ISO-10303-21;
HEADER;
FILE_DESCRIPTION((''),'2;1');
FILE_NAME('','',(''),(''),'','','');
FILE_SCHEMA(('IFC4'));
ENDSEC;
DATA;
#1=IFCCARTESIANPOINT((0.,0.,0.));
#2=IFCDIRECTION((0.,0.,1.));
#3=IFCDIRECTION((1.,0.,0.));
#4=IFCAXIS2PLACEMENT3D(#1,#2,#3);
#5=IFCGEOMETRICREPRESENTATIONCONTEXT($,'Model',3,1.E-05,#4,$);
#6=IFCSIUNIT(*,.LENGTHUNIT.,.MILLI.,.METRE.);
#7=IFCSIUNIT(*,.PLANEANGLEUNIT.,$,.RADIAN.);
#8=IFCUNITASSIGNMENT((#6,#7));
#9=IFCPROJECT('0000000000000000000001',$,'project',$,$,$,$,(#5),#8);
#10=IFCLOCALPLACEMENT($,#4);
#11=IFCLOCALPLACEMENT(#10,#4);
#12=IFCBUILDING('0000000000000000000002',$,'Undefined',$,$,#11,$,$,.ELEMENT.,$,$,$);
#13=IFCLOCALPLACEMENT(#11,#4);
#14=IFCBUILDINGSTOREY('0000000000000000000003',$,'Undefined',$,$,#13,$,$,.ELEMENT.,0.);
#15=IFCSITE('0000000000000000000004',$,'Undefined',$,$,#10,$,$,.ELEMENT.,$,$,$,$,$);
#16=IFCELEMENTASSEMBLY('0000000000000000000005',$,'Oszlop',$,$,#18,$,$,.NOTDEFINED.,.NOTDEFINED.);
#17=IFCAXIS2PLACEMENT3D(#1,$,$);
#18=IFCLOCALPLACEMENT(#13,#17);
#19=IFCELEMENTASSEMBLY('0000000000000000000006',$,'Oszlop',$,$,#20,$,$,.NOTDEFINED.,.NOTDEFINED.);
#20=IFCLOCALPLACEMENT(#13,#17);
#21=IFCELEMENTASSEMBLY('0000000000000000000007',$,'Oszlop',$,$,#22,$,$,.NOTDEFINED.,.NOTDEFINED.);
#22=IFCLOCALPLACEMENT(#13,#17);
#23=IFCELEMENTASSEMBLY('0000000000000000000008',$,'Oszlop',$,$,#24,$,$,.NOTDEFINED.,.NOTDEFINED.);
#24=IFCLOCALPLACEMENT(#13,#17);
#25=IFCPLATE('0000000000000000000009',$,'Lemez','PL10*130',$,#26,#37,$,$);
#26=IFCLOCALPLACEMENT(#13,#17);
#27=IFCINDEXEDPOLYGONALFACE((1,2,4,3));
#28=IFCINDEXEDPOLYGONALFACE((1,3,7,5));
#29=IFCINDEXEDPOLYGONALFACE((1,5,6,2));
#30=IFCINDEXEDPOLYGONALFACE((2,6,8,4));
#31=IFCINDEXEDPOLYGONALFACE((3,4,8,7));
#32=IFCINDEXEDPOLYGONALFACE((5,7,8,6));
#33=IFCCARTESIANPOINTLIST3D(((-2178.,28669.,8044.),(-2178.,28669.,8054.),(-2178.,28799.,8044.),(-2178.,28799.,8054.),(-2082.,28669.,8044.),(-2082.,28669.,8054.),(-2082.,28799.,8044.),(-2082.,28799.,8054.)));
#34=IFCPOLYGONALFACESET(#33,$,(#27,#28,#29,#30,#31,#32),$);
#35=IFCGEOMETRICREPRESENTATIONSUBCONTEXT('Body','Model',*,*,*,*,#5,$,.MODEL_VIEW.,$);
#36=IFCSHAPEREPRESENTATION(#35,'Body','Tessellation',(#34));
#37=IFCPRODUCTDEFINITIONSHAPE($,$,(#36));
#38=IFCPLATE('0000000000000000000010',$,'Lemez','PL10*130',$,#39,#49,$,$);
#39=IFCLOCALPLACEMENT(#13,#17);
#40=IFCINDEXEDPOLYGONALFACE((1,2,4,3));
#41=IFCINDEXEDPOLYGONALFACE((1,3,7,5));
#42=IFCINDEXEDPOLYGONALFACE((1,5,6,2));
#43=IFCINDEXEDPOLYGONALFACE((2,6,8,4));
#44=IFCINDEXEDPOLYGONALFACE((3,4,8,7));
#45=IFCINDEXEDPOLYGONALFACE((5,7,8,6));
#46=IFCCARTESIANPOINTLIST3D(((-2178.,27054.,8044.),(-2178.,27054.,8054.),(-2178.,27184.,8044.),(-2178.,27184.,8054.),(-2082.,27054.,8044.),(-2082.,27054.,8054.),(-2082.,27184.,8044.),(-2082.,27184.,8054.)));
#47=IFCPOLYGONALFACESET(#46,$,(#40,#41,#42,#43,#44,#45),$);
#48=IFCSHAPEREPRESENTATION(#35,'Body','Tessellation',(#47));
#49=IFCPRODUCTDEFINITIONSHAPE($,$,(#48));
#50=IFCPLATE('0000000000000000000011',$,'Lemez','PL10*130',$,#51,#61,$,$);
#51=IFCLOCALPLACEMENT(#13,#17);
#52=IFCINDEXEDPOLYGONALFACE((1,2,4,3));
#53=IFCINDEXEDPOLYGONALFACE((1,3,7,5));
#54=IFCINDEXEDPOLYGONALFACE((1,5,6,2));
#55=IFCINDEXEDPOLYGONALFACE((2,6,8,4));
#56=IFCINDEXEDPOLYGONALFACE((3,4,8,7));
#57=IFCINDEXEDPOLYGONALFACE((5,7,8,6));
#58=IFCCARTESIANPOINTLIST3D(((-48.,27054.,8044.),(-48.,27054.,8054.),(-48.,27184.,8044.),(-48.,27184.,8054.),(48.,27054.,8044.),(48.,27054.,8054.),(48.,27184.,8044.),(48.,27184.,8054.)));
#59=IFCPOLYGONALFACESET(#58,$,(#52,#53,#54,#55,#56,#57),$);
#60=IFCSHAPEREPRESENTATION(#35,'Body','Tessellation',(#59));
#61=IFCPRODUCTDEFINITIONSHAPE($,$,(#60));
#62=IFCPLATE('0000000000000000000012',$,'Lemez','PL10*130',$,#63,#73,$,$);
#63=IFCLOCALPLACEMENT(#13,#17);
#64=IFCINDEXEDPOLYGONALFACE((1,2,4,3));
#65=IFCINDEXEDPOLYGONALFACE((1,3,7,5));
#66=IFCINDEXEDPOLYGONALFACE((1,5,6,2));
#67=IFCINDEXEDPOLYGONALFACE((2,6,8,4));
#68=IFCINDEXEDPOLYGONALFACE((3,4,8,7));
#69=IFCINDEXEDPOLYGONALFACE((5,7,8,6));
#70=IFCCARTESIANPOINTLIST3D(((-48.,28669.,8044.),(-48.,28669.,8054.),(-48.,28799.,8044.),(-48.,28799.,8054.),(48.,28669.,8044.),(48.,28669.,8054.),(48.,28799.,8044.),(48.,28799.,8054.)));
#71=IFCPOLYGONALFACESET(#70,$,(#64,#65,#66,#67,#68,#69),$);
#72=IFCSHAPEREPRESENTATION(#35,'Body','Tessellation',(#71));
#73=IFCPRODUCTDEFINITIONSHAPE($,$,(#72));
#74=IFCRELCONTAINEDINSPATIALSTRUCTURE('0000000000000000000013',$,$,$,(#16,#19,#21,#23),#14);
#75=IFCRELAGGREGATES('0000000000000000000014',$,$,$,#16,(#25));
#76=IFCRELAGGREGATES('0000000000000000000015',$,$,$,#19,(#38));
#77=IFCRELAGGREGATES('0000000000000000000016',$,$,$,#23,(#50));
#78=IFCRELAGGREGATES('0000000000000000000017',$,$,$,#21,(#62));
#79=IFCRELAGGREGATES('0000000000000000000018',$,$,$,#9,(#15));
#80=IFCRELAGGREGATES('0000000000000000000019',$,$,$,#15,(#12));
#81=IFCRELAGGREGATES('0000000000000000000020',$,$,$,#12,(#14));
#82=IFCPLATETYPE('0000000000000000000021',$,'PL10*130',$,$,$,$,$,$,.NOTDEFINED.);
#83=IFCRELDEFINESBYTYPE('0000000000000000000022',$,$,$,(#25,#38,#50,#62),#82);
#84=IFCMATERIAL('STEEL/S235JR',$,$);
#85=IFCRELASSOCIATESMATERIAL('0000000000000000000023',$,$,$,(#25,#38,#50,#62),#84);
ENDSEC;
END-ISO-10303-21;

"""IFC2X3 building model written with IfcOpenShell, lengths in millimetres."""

from ifc_helpers import new_model, si_unit, frame, origin_with_axes, place, context, subcontext, project, spatial, polyline, outline, extrude, material, type_object, element, aggregate, save


model = new_model("IFC2X3")

# Units and contexts
model_context = context("Model", 3, precision=1e-05, world=origin_with_axes())
body_context = subcontext(model_context, "Body", "Model", "MODEL_VIEW")
ifc_project = project(units=[si_unit("LENGTHUNIT", "METRE", prefix="MILLI"), si_unit("PLANEANGLEUNIT", "RADIAN")], contexts=[model_context])

# Site, building, storey
site_placement = place(None, origin_with_axes())
site = spatial("IfcSite", under=ifc_project, at=site_placement, Name="Undefined", CompositionType="ELEMENT")
building_placement = place(site_placement, origin_with_axes())
building = spatial("IfcBuilding", under=site, at=building_placement, Name="Undefined", CompositionType="ELEMENT")
storey_placement = place(building_placement, origin_with_axes())
storey = spatial("IfcBuildingStorey", under=building, at=storey_placement, Name="Undefined", CompositionType="ELEMENT", Elevation=0.0)

# Element assemblies
assembly_1_placement = place(storey_placement, origin_with_axes())
assembly_1 = element("IfcElementAssembly", 1, at=assembly_1_placement, inside=storey, Name="Oszlop", AssemblyPlace="NOTDEFINED", PredefinedType="NOTDEFINED")
ifc_material_1 = material(Name="STEEL/S235JR")
assembly_2_placement = place(storey_placement, origin_with_axes())
assembly_2 = element("IfcElementAssembly", 2, at=assembly_2_placement, inside=storey, Name="Oszlop", AssemblyPlace="NOTDEFINED", PredefinedType="NOTDEFINED")
assembly_3_placement = place(storey_placement, origin_with_axes())
assembly_3 = element("IfcElementAssembly", 3, at=assembly_3_placement, inside=storey, Name="Oszlop", AssemblyPlace="NOTDEFINED", PredefinedType="NOTDEFINED")
assembly_4_placement = place(storey_placement, origin_with_axes())
assembly_4 = element("IfcElementAssembly", 4, at=assembly_4_placement, inside=storey, Name="Oszlop", AssemblyPlace="NOTDEFINED", PredefinedType="NOTDEFINED")

# Plates
plate_type_1 = type_object("IfcPlateType", Name="PL10*130", PredefinedType="NOTDEFINED")
plate_1_placement = place(assembly_1_placement, frame((-2082.0, 28734.0, 8049.0), z_axis=(0.0, 0.0, -1.0), x_axis=(-1.0, 0.0, 0.0)))
plate_1 = element("IfcPlate", 5, at=plate_1_placement, type_object=plate_type_1, material=ifc_material_1, Name="Lemez", Description="PL10*130", context=body_context, shape_type="SweptSolid", body=[
    extrude(outline(polyline([(0.0, -65.0), (0.0, 65.0), (96.0, 65.0), (96.0, -65.0), (0.0, -65.0)])), frame((0.0, 0.0, -5.0), z_axis=(0.0, 0.0, 1.0), x_axis=(1.0, 0.0, 0.0)), (0.0, 0.0, 1.0), 10.0),
])
plate_2_placement = place(assembly_2_placement, frame((-2082.0, 27119.0, 8049.0), z_axis=(0.0, 0.0, -1.0), x_axis=(-1.0, 0.0, 0.0)))
plate_2 = element("IfcPlate", 6, at=plate_2_placement, type_object=plate_type_1, material=ifc_material_1, Name="Lemez", Description="PL10*130", context=body_context, shape_type="SweptSolid", body=[
    extrude(outline(polyline([(0.0, -65.0), (0.0, 65.0), (96.0, 65.0), (96.0, -65.0), (0.0, -65.0)])), frame((0.0, 0.0, -5.0), z_axis=(0.0, 0.0, 1.0), x_axis=(1.0, 0.0, 0.0)), (0.0, 0.0, 1.0), 10.0),
])
plate_3_placement = place(assembly_4_placement, frame((48.0, 27119.0, 8049.0), z_axis=(0.0, 0.0, -1.0), x_axis=(-1.0, 0.0, 0.0)))
plate_3 = element("IfcPlate", 7, at=plate_3_placement, type_object=plate_type_1, material=ifc_material_1, Name="Lemez", Description="PL10*130", context=body_context, shape_type="SweptSolid", body=[
    extrude(outline(polyline([(0.0, -65.0), (0.0, 65.0), (96.0, 65.0), (96.0, -65.0), (0.0, -65.0)])), frame((0.0, 0.0, -5.0), z_axis=(0.0, 0.0, 1.0), x_axis=(1.0, 0.0, 0.0)), (0.0, 0.0, 1.0), 10.0),
])
plate_4_placement = place(assembly_3_placement, frame((48.0, 28734.0, 8049.0), z_axis=(0.0, 0.0, -1.0), x_axis=(-1.0, 0.0, 0.0)))
plate_4 = element("IfcPlate", 8, at=plate_4_placement, type_object=plate_type_1, material=ifc_material_1, Name="Lemez", Description="PL10*130", context=body_context, shape_type="SweptSolid", body=[
    extrude(outline(polyline([(0.0, -65.0), (0.0, 65.0), (96.0, 65.0), (96.0, -65.0), (0.0, -65.0)])), frame((0.0, 0.0, -5.0), z_axis=(0.0, 0.0, 1.0), x_axis=(1.0, 0.0, 0.0)), (0.0, 0.0, 1.0), 10.0),
])

aggregate(assembly_1, [plate_1])
aggregate(assembly_2, [plate_2])
aggregate(assembly_4, [plate_3])
aggregate(assembly_3, [plate_4])

save(model, "model.ifc")
